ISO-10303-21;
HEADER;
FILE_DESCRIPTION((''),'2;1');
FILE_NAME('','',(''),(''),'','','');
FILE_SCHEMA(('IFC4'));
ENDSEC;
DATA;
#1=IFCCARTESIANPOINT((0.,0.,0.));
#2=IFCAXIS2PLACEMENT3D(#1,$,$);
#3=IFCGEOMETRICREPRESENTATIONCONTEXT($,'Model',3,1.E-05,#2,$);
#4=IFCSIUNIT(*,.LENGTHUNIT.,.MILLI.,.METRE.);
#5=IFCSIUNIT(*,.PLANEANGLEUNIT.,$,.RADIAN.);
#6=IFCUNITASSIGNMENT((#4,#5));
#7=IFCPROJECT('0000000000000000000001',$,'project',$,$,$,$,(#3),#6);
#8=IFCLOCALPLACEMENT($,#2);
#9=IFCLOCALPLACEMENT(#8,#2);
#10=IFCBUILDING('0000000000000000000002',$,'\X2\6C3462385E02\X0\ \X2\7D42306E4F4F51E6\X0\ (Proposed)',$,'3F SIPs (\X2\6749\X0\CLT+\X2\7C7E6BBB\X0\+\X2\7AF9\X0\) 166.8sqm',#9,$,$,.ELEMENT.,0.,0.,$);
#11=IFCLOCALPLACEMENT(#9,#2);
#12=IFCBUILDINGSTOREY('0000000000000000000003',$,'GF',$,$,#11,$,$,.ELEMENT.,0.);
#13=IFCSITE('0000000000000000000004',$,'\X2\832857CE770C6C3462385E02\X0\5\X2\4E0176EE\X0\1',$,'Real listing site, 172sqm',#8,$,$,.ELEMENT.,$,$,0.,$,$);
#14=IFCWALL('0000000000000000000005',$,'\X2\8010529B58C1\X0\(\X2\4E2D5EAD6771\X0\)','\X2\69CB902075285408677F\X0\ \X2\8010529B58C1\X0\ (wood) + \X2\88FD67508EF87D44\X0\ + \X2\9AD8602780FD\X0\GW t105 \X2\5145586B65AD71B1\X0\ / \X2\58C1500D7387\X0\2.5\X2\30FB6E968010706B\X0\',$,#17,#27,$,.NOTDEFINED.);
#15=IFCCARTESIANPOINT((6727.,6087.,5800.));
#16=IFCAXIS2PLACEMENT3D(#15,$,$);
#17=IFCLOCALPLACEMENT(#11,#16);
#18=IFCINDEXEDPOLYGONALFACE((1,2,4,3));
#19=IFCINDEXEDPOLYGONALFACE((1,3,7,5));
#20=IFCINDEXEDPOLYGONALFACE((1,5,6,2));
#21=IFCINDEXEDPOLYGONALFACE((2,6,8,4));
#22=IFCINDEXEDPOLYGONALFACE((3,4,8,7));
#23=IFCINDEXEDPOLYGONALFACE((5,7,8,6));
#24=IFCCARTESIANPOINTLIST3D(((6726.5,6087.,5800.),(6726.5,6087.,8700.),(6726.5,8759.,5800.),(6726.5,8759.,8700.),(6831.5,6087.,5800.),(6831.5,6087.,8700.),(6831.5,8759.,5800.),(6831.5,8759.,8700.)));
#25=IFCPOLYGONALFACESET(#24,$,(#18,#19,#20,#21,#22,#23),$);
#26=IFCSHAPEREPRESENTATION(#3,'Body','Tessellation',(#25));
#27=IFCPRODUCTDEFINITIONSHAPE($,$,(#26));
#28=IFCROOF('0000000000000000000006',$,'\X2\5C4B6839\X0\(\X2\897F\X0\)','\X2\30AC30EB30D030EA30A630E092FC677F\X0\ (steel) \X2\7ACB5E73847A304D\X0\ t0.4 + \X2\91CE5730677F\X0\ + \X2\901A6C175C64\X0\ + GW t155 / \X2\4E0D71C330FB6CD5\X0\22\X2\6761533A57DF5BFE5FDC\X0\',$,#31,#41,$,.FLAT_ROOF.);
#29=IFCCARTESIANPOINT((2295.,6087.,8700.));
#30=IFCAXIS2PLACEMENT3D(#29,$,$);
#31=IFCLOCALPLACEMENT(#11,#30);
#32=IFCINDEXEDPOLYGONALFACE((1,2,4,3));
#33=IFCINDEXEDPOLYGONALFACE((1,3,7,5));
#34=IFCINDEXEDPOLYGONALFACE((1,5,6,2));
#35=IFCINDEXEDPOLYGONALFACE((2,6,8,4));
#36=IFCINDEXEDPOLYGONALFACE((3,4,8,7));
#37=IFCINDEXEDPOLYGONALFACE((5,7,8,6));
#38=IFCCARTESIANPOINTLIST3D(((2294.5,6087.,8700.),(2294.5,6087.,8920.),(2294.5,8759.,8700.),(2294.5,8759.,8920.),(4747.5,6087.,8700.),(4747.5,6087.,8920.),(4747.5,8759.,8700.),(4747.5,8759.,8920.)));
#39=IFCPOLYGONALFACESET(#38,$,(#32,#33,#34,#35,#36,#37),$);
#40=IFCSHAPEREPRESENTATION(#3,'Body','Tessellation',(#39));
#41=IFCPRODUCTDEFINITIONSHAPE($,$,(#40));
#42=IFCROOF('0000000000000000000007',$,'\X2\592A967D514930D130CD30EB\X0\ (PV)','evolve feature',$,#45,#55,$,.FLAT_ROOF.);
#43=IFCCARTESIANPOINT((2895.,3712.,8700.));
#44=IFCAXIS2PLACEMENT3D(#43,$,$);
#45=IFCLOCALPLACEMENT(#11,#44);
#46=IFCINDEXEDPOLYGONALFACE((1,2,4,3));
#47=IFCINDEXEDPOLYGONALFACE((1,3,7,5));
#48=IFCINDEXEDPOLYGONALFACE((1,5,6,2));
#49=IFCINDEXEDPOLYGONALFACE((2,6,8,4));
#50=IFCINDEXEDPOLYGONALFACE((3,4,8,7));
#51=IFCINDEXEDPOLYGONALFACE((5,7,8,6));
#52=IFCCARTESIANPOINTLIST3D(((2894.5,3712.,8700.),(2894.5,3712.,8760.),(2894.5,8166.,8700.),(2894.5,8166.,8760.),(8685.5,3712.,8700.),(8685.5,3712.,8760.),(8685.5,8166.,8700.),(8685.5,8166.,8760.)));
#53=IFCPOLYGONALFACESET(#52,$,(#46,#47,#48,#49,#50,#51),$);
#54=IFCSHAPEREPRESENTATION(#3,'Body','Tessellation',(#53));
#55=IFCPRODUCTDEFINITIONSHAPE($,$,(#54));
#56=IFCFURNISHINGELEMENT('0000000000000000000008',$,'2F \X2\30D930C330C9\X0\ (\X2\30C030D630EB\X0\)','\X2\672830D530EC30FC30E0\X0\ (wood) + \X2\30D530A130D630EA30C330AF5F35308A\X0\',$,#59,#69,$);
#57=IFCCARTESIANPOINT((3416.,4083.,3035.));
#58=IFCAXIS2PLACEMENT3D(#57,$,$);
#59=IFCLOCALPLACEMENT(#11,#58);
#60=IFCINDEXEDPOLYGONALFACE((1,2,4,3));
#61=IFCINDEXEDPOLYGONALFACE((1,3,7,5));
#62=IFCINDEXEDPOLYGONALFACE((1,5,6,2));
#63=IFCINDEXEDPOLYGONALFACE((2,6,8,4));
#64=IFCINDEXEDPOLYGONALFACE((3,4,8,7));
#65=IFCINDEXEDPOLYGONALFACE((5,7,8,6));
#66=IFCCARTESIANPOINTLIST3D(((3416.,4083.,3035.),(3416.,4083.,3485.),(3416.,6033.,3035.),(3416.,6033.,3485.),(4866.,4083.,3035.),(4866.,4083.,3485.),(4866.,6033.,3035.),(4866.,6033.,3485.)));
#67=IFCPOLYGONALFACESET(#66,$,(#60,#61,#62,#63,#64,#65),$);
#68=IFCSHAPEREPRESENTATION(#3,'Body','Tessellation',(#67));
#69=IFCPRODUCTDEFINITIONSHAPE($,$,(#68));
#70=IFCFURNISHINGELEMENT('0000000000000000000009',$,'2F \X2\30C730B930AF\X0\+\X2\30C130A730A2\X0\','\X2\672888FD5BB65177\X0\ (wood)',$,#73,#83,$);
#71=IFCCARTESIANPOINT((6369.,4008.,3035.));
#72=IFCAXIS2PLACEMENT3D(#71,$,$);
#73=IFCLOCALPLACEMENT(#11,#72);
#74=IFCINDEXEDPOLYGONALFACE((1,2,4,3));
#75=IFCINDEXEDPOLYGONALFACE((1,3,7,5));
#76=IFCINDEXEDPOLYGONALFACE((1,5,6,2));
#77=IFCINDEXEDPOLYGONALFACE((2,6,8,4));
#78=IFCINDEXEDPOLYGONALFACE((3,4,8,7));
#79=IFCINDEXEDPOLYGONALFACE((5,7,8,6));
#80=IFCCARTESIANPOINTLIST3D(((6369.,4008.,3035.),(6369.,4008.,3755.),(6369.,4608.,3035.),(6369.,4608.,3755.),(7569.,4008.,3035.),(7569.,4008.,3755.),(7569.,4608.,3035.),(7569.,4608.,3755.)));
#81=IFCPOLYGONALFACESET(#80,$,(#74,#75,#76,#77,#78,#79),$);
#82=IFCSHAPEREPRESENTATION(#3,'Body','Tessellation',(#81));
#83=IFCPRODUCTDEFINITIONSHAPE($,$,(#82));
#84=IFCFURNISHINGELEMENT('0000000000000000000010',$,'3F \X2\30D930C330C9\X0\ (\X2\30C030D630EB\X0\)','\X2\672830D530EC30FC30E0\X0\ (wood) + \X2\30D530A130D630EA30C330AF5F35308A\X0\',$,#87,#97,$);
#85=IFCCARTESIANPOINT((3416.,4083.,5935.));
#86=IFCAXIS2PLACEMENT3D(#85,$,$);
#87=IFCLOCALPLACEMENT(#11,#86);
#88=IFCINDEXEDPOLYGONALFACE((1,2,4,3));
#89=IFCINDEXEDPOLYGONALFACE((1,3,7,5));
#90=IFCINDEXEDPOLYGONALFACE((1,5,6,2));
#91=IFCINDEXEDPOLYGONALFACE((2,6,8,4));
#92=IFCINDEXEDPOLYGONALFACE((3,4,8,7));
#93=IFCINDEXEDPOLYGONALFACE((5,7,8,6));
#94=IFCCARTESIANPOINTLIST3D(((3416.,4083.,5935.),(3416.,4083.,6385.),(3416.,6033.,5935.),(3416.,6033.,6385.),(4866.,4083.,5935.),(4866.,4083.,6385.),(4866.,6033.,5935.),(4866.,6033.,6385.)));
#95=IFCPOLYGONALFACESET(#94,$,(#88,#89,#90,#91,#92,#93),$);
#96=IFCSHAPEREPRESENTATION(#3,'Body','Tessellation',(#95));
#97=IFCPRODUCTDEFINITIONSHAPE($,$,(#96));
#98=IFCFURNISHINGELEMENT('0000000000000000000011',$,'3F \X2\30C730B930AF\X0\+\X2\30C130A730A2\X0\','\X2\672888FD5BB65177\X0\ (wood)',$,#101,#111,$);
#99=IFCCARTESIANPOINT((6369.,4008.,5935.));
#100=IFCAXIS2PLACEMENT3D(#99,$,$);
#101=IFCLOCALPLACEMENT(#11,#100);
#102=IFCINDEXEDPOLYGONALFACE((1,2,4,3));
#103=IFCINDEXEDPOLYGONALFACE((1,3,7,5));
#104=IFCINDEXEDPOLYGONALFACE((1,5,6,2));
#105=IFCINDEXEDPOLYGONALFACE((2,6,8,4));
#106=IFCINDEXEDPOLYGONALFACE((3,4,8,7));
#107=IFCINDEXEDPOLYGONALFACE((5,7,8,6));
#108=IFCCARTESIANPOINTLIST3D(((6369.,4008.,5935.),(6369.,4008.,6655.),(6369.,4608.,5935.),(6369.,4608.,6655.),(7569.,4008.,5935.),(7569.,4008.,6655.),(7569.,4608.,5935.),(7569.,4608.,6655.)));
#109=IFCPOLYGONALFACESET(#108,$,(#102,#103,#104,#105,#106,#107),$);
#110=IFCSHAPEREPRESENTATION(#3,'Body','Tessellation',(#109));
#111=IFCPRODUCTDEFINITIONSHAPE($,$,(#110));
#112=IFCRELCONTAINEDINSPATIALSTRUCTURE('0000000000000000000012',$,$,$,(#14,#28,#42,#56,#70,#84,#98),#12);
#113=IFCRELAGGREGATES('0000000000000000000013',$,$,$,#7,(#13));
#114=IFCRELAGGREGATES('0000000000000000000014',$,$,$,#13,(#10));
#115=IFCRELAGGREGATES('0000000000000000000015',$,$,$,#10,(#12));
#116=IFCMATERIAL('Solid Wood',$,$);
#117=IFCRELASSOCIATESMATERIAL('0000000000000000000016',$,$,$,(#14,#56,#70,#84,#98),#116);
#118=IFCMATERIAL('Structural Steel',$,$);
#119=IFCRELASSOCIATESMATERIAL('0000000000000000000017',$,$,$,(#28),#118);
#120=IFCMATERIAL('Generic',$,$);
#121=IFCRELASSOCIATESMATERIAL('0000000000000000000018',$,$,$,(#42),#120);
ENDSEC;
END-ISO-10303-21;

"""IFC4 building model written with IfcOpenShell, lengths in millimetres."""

from ifc_helpers import new_model, si_unit, frame, frame_2d, origin, place, context, project, spatial, rectangle, extrude, material, element, save


model = new_model("IFC4")

# Units and contexts
model_context = context("Model", 3, precision=1e-05, world=origin())
ifc_project = project(units=[si_unit("LENGTHUNIT", "METRE", prefix="MILLI"), si_unit("PLANEANGLEUNIT", "RADIAN")], contexts=[model_context])

# Site, building, storey
site_placement = place(None, origin())
site = spatial("IfcSite", under=ifc_project, at=site_placement, Name="茨城県水戸市5丁目1", ObjectType="Real listing site, 172sqm", CompositionType="ELEMENT", RefElevation=0.0)
building_placement = place(site_placement, origin())
building = spatial("IfcBuilding", under=site, at=building_placement, Name="水戸市 終の住処 (Proposed)", ObjectType="3F SIPs (杉CLT+籾殻+竹) 166.8sqm", CompositionType="ELEMENT", ElevationOfRefHeight=0.0, ElevationOfTerrain=0.0)
storey_placement = place(building_placement, origin())
storey = spatial("IfcBuildingStorey", under=building, at=storey_placement, Name="GF", CompositionType="ELEMENT", Elevation=0.0)

# Shared definitions
ifc_material_1 = material(Name="Solid Wood")

# Wall
wall_1_placement = place(storey_placement, frame((6727.0, 6087.0, 5800.0)))
element("IfcWall", 1, at=wall_1_placement, inside=storey, material=ifc_material_1, Name="耐力壁(中庭東)", Description="構造用合板 耐力壁 (wood) + 製材軸組 + 高性能GW t105 充填断熱 / 壁倍率2.5・準耐火", PredefinedType="NOTDEFINED", context=model_context, shape_type="SweptSolid", body=[
    extrude(rectangle(XDim=105.0, YDim=2672.0, at=frame_2d((52.0, 1336.0))), frame((6727.0, 6087.0, 5800.0)), (0.0, 0.0, 1.0), 2900.0),
])

# Roofs
ifc_material_2 = material(Name="Structural Steel")
roof_1_placement = place(storey_placement, frame((2295.0, 6087.0, 8700.0)))
element("IfcRoof", 2, at=roof_1_placement, inside=storey, material=ifc_material_2, Name="屋根(西)", Description="ガルバリウム鋼板 (steel) 立平葺き t0.4 + 野地板 + 通気層 + GW t155 / 不燃・法22条区域対応", PredefinedType="FLAT_ROOF", context=model_context, shape_type="SweptSolid", body=[
    extrude(rectangle(XDim=2453.0, YDim=2672.0, at=frame_2d((1226.0, 1336.0))), frame((2295.0, 6087.0, 8700.0)), (0.0, 0.0, 1.0), 220.0),
])
ifc_material_3 = material(Name="Generic")
roof_2_placement = place(storey_placement, frame((2895.0, 3712.0, 8700.0)))
element("IfcRoof", 3, at=roof_2_placement, inside=storey, material=ifc_material_3, Name="太陽光パネル (PV)", Description="evolve feature", PredefinedType="FLAT_ROOF", context=model_context, shape_type="SweptSolid", body=[
    extrude(rectangle(XDim=5791.0, YDim=4454.0, at=frame_2d((2895.0, 2227.0))), frame((2895.0, 3712.0, 8700.0)), (0.0, 0.0, 1.0), 60.0),
])

# Furnishing elements
furnishing_1_placement = place(storey_placement, frame((3416.0, 4083.0, 3035.0)))
element("IfcFurnishingElement", 4, at=furnishing_1_placement, inside=storey, material=ifc_material_1, Name="2F ベッド (ダブル)", Description="木フレーム (wood) + ファブリック張り", context=model_context, shape_type="SweptSolid", body=[
    extrude(rectangle(XDim=1450.0, YDim=1950.0, at=frame_2d((725.0, 975.0))), frame((3416.0, 4083.0, 3035.0)), (0.0, 0.0, 1.0), 450.0),
])
furnishing_2_placement = place(storey_placement, frame((6369.0, 4008.0, 3035.0)))
element("IfcFurnishingElement", 5, at=furnishing_2_placement, inside=storey, material=ifc_material_1, Name="2F デスク+チェア", Description="木製家具 (wood)", context=model_context, shape_type="SweptSolid", body=[
    extrude(rectangle(XDim=1200.0, YDim=600.0, at=frame_2d((600.0, 300.0))), frame((6369.0, 4008.0, 3035.0)), (0.0, 0.0, 1.0), 720.0),
])
furnishing_3_placement = place(storey_placement, frame((3416.0, 4083.0, 5935.0)))
element("IfcFurnishingElement", 6, at=furnishing_3_placement, inside=storey, material=ifc_material_1, Name="3F ベッド (ダブル)", Description="木フレーム (wood) + ファブリック張り", context=model_context, shape_type="SweptSolid", body=[
    extrude(rectangle(XDim=1450.0, YDim=1950.0, at=frame_2d((725.0, 975.0))), frame((3416.0, 4083.0, 5935.0)), (0.0, 0.0, 1.0), 450.0),
])
furnishing_4_placement = place(storey_placement, frame((6369.0, 4008.0, 5935.0)))
element("IfcFurnishingElement", 7, at=furnishing_4_placement, inside=storey, material=ifc_material_1, Name="3F デスク+チェア", Description="木製家具 (wood)", context=model_context, shape_type="SweptSolid", body=[
    extrude(rectangle(XDim=1200.0, YDim=600.0, at=frame_2d((600.0, 300.0))), frame((6369.0, 4008.0, 5935.0)), (0.0, 0.0, 1.0), 720.0),
])

save(model, "model.ifc")
